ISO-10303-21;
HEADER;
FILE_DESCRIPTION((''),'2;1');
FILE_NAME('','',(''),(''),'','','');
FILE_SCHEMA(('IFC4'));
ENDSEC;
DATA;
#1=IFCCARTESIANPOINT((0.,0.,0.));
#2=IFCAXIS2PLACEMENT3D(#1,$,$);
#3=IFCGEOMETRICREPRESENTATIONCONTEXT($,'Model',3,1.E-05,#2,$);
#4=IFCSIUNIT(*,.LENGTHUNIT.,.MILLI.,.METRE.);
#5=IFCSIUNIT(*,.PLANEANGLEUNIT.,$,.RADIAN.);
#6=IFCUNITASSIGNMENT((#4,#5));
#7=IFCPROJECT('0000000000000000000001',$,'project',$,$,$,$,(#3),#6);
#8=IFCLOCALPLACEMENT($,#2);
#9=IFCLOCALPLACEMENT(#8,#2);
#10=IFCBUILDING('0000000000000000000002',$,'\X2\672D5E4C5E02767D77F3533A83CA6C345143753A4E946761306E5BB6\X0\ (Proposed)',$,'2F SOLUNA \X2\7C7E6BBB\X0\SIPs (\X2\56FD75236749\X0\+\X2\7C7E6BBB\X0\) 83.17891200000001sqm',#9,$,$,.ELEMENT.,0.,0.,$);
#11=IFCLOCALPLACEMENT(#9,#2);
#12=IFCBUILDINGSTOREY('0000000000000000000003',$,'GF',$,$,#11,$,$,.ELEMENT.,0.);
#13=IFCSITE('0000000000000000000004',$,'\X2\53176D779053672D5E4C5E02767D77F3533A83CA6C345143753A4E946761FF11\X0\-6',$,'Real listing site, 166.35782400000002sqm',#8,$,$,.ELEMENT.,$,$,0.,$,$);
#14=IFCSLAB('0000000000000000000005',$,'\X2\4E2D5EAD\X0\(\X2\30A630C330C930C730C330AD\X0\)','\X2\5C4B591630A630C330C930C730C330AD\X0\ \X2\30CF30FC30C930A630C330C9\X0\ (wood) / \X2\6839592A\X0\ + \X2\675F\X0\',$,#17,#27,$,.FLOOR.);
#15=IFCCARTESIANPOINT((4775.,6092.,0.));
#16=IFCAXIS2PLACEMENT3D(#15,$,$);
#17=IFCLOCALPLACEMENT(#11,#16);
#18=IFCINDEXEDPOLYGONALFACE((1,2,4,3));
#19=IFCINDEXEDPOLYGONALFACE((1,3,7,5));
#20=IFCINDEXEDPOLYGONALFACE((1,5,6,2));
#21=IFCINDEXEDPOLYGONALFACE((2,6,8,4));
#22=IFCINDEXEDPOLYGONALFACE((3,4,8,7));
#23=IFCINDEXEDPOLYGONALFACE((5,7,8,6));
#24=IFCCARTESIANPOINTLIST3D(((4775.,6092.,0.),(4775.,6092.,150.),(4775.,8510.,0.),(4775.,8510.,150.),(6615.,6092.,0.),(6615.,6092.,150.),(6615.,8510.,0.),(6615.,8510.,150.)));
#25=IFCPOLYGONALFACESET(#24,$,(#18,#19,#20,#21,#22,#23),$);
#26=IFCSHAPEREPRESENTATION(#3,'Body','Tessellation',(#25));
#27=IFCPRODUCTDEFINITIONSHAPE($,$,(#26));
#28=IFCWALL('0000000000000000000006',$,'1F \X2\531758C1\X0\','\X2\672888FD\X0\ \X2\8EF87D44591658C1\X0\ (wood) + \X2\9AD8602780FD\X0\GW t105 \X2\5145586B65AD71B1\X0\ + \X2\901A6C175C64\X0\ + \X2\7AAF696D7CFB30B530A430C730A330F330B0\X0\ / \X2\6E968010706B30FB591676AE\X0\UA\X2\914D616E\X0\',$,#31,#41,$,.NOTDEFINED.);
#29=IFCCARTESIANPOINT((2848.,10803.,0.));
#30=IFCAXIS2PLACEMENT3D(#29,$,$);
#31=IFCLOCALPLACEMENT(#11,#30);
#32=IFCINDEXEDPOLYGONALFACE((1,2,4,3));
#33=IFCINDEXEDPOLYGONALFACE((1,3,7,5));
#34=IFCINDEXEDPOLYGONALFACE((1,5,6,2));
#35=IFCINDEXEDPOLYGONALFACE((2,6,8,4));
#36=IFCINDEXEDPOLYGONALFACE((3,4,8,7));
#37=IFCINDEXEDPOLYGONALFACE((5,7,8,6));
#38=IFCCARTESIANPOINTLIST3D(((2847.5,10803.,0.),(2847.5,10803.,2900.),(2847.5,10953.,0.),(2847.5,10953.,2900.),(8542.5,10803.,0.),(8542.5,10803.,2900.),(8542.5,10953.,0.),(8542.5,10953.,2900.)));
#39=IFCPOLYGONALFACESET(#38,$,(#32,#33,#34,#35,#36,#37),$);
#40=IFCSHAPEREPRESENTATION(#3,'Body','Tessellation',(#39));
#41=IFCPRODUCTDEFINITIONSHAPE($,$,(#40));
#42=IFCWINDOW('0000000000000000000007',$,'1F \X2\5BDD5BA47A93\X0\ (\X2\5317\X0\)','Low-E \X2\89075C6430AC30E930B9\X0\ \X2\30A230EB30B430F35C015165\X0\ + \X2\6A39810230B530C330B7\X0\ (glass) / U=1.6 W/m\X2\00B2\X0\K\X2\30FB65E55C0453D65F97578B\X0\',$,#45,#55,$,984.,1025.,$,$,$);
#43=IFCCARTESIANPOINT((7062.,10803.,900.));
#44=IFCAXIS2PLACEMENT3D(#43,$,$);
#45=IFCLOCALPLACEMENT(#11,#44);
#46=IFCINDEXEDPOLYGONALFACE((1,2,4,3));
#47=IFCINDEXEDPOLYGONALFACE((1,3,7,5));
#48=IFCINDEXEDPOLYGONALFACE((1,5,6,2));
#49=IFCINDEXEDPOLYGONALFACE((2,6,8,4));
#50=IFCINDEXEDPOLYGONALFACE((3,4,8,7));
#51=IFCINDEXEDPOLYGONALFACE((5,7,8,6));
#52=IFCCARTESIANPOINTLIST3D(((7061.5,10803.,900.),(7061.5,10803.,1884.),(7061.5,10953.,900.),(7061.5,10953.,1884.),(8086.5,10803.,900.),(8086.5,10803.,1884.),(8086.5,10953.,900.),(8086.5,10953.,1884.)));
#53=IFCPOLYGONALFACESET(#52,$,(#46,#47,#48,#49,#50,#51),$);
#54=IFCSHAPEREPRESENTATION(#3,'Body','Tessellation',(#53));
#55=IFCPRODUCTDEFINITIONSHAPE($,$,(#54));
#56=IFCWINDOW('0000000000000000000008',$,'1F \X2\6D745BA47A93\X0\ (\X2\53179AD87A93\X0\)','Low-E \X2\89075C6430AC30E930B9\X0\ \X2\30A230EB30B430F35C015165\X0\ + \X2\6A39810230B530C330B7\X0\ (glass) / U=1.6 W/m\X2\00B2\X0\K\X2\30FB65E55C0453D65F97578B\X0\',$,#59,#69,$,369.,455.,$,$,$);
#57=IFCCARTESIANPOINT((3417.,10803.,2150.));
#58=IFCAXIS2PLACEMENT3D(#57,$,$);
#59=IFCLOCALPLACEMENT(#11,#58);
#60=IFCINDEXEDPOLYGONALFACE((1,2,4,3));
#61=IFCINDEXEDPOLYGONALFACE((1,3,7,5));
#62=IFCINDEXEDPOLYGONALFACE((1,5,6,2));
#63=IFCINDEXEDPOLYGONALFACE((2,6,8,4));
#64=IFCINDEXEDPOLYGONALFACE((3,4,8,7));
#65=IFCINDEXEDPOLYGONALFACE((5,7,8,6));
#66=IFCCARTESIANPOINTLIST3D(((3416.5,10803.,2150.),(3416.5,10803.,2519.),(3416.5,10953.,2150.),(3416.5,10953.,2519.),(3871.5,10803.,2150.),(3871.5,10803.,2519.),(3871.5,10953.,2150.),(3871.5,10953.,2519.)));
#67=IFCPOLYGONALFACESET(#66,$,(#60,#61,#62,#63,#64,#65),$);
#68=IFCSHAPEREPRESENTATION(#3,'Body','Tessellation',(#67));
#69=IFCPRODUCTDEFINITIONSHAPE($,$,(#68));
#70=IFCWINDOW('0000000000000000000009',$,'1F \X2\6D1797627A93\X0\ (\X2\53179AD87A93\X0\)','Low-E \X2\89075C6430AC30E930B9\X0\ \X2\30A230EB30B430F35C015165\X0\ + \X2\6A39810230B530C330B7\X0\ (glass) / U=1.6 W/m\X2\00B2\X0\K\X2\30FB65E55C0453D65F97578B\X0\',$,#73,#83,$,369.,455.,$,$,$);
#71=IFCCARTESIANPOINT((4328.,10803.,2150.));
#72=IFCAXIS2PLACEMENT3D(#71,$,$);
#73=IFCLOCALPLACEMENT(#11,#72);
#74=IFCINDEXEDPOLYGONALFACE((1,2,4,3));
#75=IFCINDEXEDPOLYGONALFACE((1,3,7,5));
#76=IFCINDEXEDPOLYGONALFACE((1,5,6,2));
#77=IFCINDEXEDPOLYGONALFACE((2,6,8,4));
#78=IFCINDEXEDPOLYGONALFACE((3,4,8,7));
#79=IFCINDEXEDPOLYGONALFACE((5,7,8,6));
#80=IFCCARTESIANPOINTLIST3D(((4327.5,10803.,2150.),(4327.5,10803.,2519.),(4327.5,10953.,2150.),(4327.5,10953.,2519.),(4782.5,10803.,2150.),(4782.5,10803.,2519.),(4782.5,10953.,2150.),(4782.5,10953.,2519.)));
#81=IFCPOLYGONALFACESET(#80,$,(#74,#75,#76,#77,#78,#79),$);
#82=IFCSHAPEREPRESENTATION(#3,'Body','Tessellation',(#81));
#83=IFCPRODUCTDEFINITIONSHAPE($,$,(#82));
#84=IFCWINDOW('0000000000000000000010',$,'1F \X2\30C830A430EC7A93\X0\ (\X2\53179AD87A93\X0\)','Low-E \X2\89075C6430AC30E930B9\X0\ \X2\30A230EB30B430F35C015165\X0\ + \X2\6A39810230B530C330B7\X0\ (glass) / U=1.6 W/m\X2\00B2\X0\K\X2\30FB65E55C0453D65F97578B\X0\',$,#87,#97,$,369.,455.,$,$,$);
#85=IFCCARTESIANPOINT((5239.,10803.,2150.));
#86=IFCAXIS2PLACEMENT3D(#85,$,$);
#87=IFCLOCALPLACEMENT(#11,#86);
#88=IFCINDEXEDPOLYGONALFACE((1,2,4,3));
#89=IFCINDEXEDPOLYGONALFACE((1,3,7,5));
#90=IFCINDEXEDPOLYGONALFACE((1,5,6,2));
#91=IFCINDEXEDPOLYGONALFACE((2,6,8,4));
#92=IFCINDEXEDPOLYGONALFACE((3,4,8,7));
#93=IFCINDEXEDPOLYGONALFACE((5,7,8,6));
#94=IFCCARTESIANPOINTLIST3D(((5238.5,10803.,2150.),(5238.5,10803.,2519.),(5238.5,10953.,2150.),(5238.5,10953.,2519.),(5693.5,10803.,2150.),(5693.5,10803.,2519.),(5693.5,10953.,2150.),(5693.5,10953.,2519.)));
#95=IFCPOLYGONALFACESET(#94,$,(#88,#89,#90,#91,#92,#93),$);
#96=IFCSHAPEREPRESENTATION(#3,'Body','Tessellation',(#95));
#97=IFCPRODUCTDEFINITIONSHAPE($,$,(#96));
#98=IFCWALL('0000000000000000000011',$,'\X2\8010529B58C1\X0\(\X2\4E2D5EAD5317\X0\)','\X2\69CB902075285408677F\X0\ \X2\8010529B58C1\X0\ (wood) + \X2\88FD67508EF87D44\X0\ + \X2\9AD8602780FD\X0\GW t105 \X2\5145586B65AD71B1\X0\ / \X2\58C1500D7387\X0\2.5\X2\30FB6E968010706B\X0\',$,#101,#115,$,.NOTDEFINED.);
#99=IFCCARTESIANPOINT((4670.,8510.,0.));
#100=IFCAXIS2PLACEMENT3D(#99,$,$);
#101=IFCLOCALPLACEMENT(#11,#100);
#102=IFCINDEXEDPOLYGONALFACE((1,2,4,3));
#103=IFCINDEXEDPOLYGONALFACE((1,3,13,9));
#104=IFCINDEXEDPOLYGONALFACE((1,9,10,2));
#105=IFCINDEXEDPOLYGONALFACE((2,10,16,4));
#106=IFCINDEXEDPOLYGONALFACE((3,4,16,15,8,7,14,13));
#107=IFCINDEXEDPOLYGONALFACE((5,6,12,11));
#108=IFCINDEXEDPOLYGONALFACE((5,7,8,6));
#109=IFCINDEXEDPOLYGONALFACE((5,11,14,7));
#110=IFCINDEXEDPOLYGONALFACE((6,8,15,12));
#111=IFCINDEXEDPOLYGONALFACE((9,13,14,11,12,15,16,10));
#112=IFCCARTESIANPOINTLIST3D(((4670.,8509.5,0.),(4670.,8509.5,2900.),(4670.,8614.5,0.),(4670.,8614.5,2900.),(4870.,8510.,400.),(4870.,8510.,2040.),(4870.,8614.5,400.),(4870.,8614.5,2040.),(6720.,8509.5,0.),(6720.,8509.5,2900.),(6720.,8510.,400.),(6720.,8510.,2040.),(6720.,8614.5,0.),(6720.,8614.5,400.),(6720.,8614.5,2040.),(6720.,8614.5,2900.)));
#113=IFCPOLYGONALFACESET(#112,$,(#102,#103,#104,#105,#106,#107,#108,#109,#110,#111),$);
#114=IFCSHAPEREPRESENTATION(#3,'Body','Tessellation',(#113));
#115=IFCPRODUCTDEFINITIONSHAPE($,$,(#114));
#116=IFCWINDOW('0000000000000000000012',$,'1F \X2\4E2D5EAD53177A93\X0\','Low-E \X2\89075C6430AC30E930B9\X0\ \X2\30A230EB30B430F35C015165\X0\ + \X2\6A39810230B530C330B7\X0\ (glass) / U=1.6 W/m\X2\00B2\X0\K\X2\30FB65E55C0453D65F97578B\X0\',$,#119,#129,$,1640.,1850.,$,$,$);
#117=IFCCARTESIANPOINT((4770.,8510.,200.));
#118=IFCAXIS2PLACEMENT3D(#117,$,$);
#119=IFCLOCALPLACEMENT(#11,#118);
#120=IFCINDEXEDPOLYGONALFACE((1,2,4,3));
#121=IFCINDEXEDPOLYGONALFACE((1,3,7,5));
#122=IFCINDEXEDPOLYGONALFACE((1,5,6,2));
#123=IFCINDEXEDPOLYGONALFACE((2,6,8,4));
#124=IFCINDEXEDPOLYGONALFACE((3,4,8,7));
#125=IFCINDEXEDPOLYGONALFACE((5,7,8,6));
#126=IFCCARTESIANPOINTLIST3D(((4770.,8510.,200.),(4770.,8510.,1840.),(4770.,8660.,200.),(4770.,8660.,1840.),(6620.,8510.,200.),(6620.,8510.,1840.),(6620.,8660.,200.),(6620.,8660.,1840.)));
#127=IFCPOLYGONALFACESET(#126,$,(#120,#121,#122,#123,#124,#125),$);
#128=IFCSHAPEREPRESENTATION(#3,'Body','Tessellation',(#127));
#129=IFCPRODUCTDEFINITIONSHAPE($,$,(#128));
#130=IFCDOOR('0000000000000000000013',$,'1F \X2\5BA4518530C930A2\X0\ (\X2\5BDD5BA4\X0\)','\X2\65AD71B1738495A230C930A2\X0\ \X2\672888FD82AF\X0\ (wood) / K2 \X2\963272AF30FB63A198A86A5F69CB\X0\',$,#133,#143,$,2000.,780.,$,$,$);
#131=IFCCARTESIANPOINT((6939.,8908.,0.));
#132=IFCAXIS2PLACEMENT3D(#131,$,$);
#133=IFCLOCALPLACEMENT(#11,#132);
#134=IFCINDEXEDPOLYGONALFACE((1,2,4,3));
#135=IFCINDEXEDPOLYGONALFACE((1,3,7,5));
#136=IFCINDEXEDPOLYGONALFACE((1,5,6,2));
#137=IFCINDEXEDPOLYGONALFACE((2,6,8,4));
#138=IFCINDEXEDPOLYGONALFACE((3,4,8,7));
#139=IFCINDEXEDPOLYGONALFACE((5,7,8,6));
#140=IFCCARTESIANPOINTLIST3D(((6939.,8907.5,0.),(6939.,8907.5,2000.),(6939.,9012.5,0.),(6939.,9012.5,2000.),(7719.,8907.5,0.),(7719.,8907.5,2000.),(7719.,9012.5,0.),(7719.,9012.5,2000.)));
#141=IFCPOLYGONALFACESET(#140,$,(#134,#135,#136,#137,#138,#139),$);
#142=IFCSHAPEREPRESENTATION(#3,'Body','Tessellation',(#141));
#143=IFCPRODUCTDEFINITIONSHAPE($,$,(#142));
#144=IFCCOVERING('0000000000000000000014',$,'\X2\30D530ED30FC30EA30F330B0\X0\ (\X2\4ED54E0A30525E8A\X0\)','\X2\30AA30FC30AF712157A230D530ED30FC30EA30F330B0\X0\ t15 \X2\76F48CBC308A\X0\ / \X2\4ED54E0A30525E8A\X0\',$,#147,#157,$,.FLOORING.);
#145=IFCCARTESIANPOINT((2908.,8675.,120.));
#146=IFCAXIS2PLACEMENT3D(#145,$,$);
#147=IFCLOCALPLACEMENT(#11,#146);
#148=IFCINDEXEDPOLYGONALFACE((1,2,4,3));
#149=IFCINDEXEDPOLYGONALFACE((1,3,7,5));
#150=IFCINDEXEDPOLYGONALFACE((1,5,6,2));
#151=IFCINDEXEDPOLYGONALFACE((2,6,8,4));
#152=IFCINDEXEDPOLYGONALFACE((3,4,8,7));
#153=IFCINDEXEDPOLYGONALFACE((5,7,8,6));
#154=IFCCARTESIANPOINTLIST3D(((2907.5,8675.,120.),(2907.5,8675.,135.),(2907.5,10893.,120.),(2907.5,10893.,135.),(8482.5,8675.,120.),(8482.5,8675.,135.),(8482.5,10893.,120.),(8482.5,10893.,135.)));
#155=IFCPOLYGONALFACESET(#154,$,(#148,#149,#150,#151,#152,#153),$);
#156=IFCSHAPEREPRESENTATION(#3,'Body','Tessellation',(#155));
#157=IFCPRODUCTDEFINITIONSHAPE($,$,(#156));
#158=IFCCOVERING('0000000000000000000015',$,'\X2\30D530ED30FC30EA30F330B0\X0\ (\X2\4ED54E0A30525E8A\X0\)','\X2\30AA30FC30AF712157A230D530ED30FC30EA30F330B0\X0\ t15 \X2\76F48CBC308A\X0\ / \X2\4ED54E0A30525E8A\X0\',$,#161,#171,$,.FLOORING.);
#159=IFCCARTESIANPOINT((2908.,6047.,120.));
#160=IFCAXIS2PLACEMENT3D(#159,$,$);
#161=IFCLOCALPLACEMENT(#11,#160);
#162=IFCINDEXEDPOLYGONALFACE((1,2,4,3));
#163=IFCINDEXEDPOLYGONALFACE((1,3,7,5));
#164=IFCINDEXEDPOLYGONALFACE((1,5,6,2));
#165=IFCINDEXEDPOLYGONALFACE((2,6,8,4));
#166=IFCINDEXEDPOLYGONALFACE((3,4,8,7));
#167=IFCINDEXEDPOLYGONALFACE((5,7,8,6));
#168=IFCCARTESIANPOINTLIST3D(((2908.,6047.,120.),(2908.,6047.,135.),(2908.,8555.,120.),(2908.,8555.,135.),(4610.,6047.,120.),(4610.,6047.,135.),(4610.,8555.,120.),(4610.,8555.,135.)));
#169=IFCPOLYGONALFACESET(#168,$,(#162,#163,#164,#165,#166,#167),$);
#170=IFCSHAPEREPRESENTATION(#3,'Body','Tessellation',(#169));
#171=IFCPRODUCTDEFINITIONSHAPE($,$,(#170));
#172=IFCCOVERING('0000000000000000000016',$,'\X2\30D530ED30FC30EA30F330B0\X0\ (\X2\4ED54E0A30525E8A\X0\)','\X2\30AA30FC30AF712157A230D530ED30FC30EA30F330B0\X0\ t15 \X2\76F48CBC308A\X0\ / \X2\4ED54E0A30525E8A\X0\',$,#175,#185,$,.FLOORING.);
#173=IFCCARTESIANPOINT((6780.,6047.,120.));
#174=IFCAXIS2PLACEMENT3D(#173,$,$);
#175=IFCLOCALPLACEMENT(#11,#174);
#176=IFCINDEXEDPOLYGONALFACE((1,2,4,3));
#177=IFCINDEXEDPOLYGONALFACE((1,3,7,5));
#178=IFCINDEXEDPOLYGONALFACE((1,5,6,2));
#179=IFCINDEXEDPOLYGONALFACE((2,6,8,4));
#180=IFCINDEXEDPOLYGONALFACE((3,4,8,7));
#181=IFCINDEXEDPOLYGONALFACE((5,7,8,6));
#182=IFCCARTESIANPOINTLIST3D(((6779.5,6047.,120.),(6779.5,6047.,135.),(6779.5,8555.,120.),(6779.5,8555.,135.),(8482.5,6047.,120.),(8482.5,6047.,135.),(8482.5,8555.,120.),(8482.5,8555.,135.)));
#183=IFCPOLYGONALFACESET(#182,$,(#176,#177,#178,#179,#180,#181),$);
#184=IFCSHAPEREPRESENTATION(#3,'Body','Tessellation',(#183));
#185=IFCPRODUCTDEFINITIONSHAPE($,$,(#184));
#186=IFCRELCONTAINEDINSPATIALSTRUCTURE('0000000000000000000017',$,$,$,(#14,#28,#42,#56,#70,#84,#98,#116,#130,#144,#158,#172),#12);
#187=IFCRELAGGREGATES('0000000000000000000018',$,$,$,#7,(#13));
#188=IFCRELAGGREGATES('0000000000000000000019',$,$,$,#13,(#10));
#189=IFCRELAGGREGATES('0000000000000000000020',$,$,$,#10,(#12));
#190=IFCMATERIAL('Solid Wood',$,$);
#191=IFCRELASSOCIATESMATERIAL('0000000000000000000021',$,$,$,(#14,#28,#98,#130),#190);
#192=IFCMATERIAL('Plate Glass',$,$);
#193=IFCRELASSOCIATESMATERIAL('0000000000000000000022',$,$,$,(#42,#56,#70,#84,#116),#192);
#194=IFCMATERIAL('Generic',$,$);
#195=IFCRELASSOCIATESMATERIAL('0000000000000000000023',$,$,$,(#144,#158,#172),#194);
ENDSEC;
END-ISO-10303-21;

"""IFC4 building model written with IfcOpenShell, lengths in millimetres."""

from ifc_helpers import new_model, si_unit, frame, frame_2d, origin, place, context, project, spatial, rectangle, extrude, material, element, fill, save


model = new_model("IFC4")

# Units and contexts
model_context = context("Model", 3, precision=1e-05, world=origin())
ifc_project = project(units=[si_unit("LENGTHUNIT", "METRE", prefix="MILLI"), si_unit("PLANEANGLEUNIT", "RADIAN")], contexts=[model_context])

# Site, building, storey
site_placement = place(None, origin())
site = spatial("IfcSite", under=ifc_project, at=site_placement, Name="北海道札幌市白石区菊水元町五条１-6", ObjectType="Real listing site, 166.35782400000002sqm", CompositionType="ELEMENT", RefElevation=0.0)
building_placement = place(site_placement, origin())
building = spatial("IfcBuilding", under=site, at=building_placement, Name="札幌市白石区菊水元町五条の家 (Proposed)", ObjectType="2F SOLUNA 籾殻SIPs (国産杉+籾殻) 83.17891200000001sqm", CompositionType="ELEMENT", ElevationOfRefHeight=0.0, ElevationOfTerrain=0.0)
storey_placement = place(building_placement, origin())
storey = spatial("IfcBuildingStorey", under=building, at=storey_placement, Name="GF", CompositionType="ELEMENT", Elevation=0.0)

# Slab
ifc_material_1 = material(Name="Solid Wood")
slab_1_placement = place(storey_placement, frame((4775.0, 6092.0, 0.0)))
element("IfcSlab", 1, at=slab_1_placement, inside=storey, material=ifc_material_1, Name="中庭(ウッドデッキ)", Description="屋外ウッドデッキ ハードウッド (wood) / 根太 + 束", PredefinedType="FLOOR", context=model_context, shape_type="SweptSolid", body=[
    extrude(rectangle(XDim=1840.0, YDim=2418.0, at=frame_2d((920.0, 1209.0))), frame((4775.0, 6092.0, 0.0)), (0.0, 0.0, 1.0), 150.0),
])

# Wall, openings, windows
wall_1_placement = place(storey_placement, frame((2848.0, 10803.0, 0.0)))
wall_1 = element("IfcWall", 2, at=wall_1_placement, inside=storey, material=ifc_material_1, Name="1F 北壁", Description="木製 軸組外壁 (wood) + 高性能GW t105 充填断熱 + 通気層 + 窯業系サイディング / 準耐火・外皮UA配慮", PredefinedType="NOTDEFINED", context=model_context, shape_type="SweptSolid", body=[
    extrude(rectangle(XDim=5695.0, YDim=150.0, at=frame_2d((2847.0, 75.0))), frame((2848.0, 10803.0, 0.0)), (0.0, 0.0, 1.0), 2900.0),
])
opening_1_placement = place(storey_placement, frame((7062.0, 10803.0, 900.0)))
opening_1 = element("IfcOpeningElement", 3, at=opening_1_placement, cuts=wall_1, PredefinedType="NOTDEFINED", context=model_context, shape_type="SweptSolid", body=[
    extrude(rectangle(XDim=1025.0, YDim=150.0, at=frame_2d((512.0, 75.0))), frame((7062.0, 10803.0, 900.0)), (0.0, 0.0, 1.0), 984.0),
])
opening_2_placement = place(storey_placement, frame((3417.0, 10803.0, 2150.0)))
opening_2 = element("IfcOpeningElement", 4, at=opening_2_placement, cuts=wall_1, PredefinedType="NOTDEFINED", context=model_context, shape_type="SweptSolid", body=[
    extrude(rectangle(XDim=455.0, YDim=150.0, at=frame_2d((227.0, 75.0))), frame((3417.0, 10803.0, 2150.0)), (0.0, 0.0, 1.0), 369.0),
])
opening_3_placement = place(storey_placement, frame((4328.0, 10803.0, 2150.0)))
opening_3 = element("IfcOpeningElement", 5, at=opening_3_placement, cuts=wall_1, PredefinedType="NOTDEFINED", context=model_context, shape_type="SweptSolid", body=[
    extrude(rectangle(XDim=455.0, YDim=150.0, at=frame_2d((227.0, 75.0))), frame((4328.0, 10803.0, 2150.0)), (0.0, 0.0, 1.0), 369.0),
])
opening_4_placement = place(storey_placement, frame((5239.0, 10803.0, 2150.0)))
opening_4 = element("IfcOpeningElement", 6, at=opening_4_placement, cuts=wall_1, PredefinedType="NOTDEFINED", context=model_context, shape_type="SweptSolid", body=[
    extrude(rectangle(XDim=455.0, YDim=150.0, at=frame_2d((227.0, 75.0))), frame((5239.0, 10803.0, 2150.0)), (0.0, 0.0, 1.0), 369.0),
])
ifc_material_2 = material(Name="Plate Glass")
window_1_placement = place(storey_placement, frame((7062.0, 10803.0, 900.0)))
window_1 = element("IfcWindow", 7, at=window_1_placement, inside=storey, material=ifc_material_2, Name="1F 寝室窓 (北)", Description="Low-E 複層ガラス アルゴン封入 + 樹脂サッシ (glass) / U=1.6 W/m²K・日射取得型", OverallHeight=984.0, OverallWidth=1025.0, context=model_context, shape_type="SweptSolid", body=[
    extrude(rectangle(XDim=1025.0, YDim=150.0, at=frame_2d((512.0, 75.0))), frame((7062.0, 10803.0, 900.0)), (0.0, 0.0, 1.0), 984.0),
])
fill(opening_1, window_1)
window_2_placement = place(storey_placement, frame((3417.0, 10803.0, 2150.0)))
window_2 = element("IfcWindow", 8, at=window_2_placement, inside=storey, material=ifc_material_2, Name="1F 浴室窓 (北高窓)", Description="Low-E 複層ガラス アルゴン封入 + 樹脂サッシ (glass) / U=1.6 W/m²K・日射取得型", OverallHeight=369.0, OverallWidth=455.0, context=model_context, shape_type="SweptSolid", body=[
    extrude(rectangle(XDim=455.0, YDim=150.0, at=frame_2d((227.0, 75.0))), frame((3417.0, 10803.0, 2150.0)), (0.0, 0.0, 1.0), 369.0),
])
fill(opening_2, window_2)
window_3_placement = place(storey_placement, frame((4328.0, 10803.0, 2150.0)))
window_3 = element("IfcWindow", 9, at=window_3_placement, inside=storey, material=ifc_material_2, Name="1F 洗面窓 (北高窓)", Description="Low-E 複層ガラス アルゴン封入 + 樹脂サッシ (glass) / U=1.6 W/m²K・日射取得型", OverallHeight=369.0, OverallWidth=455.0, context=model_context, shape_type="SweptSolid", body=[
    extrude(rectangle(XDim=455.0, YDim=150.0, at=frame_2d((227.0, 75.0))), frame((4328.0, 10803.0, 2150.0)), (0.0, 0.0, 1.0), 369.0),
])
fill(opening_3, window_3)
window_4_placement = place(storey_placement, frame((5239.0, 10803.0, 2150.0)))
window_4 = element("IfcWindow", 10, at=window_4_placement, inside=storey, material=ifc_material_2, Name="1F トイレ窓 (北高窓)", Description="Low-E 複層ガラス アルゴン封入 + 樹脂サッシ (glass) / U=1.6 W/m²K・日射取得型", OverallHeight=369.0, OverallWidth=455.0, context=model_context, shape_type="SweptSolid", body=[
    extrude(rectangle(XDim=455.0, YDim=150.0, at=frame_2d((227.0, 75.0))), frame((5239.0, 10803.0, 2150.0)), (0.0, 0.0, 1.0), 369.0),
])
fill(opening_4, window_4)

# Wall, opening, window
wall_2_placement = place(storey_placement, frame((4670.0, 8510.0, 0.0)))
wall_2 = element("IfcWall", 11, at=wall_2_placement, inside=storey, material=ifc_material_1, Name="耐力壁(中庭北)", Description="構造用合板 耐力壁 (wood) + 製材軸組 + 高性能GW t105 充填断熱 / 壁倍率2.5・準耐火", PredefinedType="NOTDEFINED", context=model_context, shape_type="SweptSolid", body=[
    extrude(rectangle(XDim=2050.0, YDim=105.0, at=frame_2d((1025.0, 52.0))), frame((4670.0, 8510.0, 0.0)), (0.0, 0.0, 1.0), 2900.0),
])
opening_5_placement = place(storey_placement, frame((4770.0, 8510.0, 200.0)))
opening_5 = element("IfcOpeningElement", 12, at=opening_5_placement, cuts=wall_2, PredefinedType="NOTDEFINED", context=model_context, shape_type="SweptSolid", body=[
    extrude(rectangle(XDim=1850.0, YDim=150.0, at=frame_2d((925.0, 75.0))), frame((4770.0, 8510.0, 200.0)), (0.0, 0.0, 1.0), 1640.0),
])
window_5_placement = place(storey_placement, frame((4770.0, 8510.0, 200.0)))
window_5 = element("IfcWindow", 13, at=window_5_placement, inside=storey, material=ifc_material_2, Name="1F 中庭北窓", Description="Low-E 複層ガラス アルゴン封入 + 樹脂サッシ (glass) / U=1.6 W/m²K・日射取得型", OverallHeight=1640.0, OverallWidth=1850.0, context=model_context, shape_type="SweptSolid", body=[
    extrude(rectangle(XDim=1850.0, YDim=150.0, at=frame_2d((925.0, 75.0))), frame((4770.0, 8510.0, 200.0)), (0.0, 0.0, 1.0), 1640.0),
])
fill(opening_5, window_5)

# Door
door_1_placement = place(storey_placement, frame((6939.0, 8908.0, 0.0)))
element("IfcDoor", 14, at=door_1_placement, inside=storey, material=ifc_material_1, Name="1F 室内ドア (寝室)", Description="断熱玄関ドア 木製芯 (wood) / K2 防犯・採風機構", OverallHeight=2000.0, OverallWidth=780.0, context=model_context, shape_type="SweptSolid", body=[
    extrude(rectangle(XDim=780.0, YDim=105.0, at=frame_2d((390.0, 52.0))), frame((6939.0, 8908.0, 0.0)), (0.0, 0.0, 1.0), 2000.0),
])

# Coverings
ifc_material_3 = material(Name="Generic")
covering_1_placement = place(storey_placement, frame((2908.0, 8675.0, 120.0)))
element("IfcCovering", 15, at=covering_1_placement, inside=storey, material=ifc_material_3, Name="フローリング (仕上げ床)", Description="オーク無垢フローリング t15 直貼り / 仕上げ床", PredefinedType="FLOORING", context=model_context, shape_type="SweptSolid", body=[
    extrude(rectangle(XDim=5575.0, YDim=2218.0, at=frame_2d((2787.0, 1109.0))), frame((2908.0, 8675.0, 120.0)), (0.0, 0.0, 1.0), 15.0),
])
covering_2_placement = place(storey_placement, frame((2908.0, 6047.0, 120.0)))
element("IfcCovering", 16, at=covering_2_placement, inside=storey, material=ifc_material_3, Name="フローリング (仕上げ床)", Description="オーク無垢フローリング t15 直貼り / 仕上げ床", PredefinedType="FLOORING", context=model_context, shape_type="SweptSolid", body=[
    extrude(rectangle(XDim=1702.0, YDim=2508.0, at=frame_2d((851.0, 1254.0))), frame((2908.0, 6047.0, 120.0)), (0.0, 0.0, 1.0), 15.0),
])
covering_3_placement = place(storey_placement, frame((6780.0, 6047.0, 120.0)))
element("IfcCovering", 17, at=covering_3_placement, inside=storey, material=ifc_material_3, Name="フローリング (仕上げ床)", Description="オーク無垢フローリング t15 直貼り / 仕上げ床", PredefinedType="FLOORING", context=model_context, shape_type="SweptSolid", body=[
    extrude(rectangle(XDim=1703.0, YDim=2508.0, at=frame_2d((851.0, 1254.0))), frame((6780.0, 6047.0, 120.0)), (0.0, 0.0, 1.0), 15.0),
])

save(model, "model.ifc")
